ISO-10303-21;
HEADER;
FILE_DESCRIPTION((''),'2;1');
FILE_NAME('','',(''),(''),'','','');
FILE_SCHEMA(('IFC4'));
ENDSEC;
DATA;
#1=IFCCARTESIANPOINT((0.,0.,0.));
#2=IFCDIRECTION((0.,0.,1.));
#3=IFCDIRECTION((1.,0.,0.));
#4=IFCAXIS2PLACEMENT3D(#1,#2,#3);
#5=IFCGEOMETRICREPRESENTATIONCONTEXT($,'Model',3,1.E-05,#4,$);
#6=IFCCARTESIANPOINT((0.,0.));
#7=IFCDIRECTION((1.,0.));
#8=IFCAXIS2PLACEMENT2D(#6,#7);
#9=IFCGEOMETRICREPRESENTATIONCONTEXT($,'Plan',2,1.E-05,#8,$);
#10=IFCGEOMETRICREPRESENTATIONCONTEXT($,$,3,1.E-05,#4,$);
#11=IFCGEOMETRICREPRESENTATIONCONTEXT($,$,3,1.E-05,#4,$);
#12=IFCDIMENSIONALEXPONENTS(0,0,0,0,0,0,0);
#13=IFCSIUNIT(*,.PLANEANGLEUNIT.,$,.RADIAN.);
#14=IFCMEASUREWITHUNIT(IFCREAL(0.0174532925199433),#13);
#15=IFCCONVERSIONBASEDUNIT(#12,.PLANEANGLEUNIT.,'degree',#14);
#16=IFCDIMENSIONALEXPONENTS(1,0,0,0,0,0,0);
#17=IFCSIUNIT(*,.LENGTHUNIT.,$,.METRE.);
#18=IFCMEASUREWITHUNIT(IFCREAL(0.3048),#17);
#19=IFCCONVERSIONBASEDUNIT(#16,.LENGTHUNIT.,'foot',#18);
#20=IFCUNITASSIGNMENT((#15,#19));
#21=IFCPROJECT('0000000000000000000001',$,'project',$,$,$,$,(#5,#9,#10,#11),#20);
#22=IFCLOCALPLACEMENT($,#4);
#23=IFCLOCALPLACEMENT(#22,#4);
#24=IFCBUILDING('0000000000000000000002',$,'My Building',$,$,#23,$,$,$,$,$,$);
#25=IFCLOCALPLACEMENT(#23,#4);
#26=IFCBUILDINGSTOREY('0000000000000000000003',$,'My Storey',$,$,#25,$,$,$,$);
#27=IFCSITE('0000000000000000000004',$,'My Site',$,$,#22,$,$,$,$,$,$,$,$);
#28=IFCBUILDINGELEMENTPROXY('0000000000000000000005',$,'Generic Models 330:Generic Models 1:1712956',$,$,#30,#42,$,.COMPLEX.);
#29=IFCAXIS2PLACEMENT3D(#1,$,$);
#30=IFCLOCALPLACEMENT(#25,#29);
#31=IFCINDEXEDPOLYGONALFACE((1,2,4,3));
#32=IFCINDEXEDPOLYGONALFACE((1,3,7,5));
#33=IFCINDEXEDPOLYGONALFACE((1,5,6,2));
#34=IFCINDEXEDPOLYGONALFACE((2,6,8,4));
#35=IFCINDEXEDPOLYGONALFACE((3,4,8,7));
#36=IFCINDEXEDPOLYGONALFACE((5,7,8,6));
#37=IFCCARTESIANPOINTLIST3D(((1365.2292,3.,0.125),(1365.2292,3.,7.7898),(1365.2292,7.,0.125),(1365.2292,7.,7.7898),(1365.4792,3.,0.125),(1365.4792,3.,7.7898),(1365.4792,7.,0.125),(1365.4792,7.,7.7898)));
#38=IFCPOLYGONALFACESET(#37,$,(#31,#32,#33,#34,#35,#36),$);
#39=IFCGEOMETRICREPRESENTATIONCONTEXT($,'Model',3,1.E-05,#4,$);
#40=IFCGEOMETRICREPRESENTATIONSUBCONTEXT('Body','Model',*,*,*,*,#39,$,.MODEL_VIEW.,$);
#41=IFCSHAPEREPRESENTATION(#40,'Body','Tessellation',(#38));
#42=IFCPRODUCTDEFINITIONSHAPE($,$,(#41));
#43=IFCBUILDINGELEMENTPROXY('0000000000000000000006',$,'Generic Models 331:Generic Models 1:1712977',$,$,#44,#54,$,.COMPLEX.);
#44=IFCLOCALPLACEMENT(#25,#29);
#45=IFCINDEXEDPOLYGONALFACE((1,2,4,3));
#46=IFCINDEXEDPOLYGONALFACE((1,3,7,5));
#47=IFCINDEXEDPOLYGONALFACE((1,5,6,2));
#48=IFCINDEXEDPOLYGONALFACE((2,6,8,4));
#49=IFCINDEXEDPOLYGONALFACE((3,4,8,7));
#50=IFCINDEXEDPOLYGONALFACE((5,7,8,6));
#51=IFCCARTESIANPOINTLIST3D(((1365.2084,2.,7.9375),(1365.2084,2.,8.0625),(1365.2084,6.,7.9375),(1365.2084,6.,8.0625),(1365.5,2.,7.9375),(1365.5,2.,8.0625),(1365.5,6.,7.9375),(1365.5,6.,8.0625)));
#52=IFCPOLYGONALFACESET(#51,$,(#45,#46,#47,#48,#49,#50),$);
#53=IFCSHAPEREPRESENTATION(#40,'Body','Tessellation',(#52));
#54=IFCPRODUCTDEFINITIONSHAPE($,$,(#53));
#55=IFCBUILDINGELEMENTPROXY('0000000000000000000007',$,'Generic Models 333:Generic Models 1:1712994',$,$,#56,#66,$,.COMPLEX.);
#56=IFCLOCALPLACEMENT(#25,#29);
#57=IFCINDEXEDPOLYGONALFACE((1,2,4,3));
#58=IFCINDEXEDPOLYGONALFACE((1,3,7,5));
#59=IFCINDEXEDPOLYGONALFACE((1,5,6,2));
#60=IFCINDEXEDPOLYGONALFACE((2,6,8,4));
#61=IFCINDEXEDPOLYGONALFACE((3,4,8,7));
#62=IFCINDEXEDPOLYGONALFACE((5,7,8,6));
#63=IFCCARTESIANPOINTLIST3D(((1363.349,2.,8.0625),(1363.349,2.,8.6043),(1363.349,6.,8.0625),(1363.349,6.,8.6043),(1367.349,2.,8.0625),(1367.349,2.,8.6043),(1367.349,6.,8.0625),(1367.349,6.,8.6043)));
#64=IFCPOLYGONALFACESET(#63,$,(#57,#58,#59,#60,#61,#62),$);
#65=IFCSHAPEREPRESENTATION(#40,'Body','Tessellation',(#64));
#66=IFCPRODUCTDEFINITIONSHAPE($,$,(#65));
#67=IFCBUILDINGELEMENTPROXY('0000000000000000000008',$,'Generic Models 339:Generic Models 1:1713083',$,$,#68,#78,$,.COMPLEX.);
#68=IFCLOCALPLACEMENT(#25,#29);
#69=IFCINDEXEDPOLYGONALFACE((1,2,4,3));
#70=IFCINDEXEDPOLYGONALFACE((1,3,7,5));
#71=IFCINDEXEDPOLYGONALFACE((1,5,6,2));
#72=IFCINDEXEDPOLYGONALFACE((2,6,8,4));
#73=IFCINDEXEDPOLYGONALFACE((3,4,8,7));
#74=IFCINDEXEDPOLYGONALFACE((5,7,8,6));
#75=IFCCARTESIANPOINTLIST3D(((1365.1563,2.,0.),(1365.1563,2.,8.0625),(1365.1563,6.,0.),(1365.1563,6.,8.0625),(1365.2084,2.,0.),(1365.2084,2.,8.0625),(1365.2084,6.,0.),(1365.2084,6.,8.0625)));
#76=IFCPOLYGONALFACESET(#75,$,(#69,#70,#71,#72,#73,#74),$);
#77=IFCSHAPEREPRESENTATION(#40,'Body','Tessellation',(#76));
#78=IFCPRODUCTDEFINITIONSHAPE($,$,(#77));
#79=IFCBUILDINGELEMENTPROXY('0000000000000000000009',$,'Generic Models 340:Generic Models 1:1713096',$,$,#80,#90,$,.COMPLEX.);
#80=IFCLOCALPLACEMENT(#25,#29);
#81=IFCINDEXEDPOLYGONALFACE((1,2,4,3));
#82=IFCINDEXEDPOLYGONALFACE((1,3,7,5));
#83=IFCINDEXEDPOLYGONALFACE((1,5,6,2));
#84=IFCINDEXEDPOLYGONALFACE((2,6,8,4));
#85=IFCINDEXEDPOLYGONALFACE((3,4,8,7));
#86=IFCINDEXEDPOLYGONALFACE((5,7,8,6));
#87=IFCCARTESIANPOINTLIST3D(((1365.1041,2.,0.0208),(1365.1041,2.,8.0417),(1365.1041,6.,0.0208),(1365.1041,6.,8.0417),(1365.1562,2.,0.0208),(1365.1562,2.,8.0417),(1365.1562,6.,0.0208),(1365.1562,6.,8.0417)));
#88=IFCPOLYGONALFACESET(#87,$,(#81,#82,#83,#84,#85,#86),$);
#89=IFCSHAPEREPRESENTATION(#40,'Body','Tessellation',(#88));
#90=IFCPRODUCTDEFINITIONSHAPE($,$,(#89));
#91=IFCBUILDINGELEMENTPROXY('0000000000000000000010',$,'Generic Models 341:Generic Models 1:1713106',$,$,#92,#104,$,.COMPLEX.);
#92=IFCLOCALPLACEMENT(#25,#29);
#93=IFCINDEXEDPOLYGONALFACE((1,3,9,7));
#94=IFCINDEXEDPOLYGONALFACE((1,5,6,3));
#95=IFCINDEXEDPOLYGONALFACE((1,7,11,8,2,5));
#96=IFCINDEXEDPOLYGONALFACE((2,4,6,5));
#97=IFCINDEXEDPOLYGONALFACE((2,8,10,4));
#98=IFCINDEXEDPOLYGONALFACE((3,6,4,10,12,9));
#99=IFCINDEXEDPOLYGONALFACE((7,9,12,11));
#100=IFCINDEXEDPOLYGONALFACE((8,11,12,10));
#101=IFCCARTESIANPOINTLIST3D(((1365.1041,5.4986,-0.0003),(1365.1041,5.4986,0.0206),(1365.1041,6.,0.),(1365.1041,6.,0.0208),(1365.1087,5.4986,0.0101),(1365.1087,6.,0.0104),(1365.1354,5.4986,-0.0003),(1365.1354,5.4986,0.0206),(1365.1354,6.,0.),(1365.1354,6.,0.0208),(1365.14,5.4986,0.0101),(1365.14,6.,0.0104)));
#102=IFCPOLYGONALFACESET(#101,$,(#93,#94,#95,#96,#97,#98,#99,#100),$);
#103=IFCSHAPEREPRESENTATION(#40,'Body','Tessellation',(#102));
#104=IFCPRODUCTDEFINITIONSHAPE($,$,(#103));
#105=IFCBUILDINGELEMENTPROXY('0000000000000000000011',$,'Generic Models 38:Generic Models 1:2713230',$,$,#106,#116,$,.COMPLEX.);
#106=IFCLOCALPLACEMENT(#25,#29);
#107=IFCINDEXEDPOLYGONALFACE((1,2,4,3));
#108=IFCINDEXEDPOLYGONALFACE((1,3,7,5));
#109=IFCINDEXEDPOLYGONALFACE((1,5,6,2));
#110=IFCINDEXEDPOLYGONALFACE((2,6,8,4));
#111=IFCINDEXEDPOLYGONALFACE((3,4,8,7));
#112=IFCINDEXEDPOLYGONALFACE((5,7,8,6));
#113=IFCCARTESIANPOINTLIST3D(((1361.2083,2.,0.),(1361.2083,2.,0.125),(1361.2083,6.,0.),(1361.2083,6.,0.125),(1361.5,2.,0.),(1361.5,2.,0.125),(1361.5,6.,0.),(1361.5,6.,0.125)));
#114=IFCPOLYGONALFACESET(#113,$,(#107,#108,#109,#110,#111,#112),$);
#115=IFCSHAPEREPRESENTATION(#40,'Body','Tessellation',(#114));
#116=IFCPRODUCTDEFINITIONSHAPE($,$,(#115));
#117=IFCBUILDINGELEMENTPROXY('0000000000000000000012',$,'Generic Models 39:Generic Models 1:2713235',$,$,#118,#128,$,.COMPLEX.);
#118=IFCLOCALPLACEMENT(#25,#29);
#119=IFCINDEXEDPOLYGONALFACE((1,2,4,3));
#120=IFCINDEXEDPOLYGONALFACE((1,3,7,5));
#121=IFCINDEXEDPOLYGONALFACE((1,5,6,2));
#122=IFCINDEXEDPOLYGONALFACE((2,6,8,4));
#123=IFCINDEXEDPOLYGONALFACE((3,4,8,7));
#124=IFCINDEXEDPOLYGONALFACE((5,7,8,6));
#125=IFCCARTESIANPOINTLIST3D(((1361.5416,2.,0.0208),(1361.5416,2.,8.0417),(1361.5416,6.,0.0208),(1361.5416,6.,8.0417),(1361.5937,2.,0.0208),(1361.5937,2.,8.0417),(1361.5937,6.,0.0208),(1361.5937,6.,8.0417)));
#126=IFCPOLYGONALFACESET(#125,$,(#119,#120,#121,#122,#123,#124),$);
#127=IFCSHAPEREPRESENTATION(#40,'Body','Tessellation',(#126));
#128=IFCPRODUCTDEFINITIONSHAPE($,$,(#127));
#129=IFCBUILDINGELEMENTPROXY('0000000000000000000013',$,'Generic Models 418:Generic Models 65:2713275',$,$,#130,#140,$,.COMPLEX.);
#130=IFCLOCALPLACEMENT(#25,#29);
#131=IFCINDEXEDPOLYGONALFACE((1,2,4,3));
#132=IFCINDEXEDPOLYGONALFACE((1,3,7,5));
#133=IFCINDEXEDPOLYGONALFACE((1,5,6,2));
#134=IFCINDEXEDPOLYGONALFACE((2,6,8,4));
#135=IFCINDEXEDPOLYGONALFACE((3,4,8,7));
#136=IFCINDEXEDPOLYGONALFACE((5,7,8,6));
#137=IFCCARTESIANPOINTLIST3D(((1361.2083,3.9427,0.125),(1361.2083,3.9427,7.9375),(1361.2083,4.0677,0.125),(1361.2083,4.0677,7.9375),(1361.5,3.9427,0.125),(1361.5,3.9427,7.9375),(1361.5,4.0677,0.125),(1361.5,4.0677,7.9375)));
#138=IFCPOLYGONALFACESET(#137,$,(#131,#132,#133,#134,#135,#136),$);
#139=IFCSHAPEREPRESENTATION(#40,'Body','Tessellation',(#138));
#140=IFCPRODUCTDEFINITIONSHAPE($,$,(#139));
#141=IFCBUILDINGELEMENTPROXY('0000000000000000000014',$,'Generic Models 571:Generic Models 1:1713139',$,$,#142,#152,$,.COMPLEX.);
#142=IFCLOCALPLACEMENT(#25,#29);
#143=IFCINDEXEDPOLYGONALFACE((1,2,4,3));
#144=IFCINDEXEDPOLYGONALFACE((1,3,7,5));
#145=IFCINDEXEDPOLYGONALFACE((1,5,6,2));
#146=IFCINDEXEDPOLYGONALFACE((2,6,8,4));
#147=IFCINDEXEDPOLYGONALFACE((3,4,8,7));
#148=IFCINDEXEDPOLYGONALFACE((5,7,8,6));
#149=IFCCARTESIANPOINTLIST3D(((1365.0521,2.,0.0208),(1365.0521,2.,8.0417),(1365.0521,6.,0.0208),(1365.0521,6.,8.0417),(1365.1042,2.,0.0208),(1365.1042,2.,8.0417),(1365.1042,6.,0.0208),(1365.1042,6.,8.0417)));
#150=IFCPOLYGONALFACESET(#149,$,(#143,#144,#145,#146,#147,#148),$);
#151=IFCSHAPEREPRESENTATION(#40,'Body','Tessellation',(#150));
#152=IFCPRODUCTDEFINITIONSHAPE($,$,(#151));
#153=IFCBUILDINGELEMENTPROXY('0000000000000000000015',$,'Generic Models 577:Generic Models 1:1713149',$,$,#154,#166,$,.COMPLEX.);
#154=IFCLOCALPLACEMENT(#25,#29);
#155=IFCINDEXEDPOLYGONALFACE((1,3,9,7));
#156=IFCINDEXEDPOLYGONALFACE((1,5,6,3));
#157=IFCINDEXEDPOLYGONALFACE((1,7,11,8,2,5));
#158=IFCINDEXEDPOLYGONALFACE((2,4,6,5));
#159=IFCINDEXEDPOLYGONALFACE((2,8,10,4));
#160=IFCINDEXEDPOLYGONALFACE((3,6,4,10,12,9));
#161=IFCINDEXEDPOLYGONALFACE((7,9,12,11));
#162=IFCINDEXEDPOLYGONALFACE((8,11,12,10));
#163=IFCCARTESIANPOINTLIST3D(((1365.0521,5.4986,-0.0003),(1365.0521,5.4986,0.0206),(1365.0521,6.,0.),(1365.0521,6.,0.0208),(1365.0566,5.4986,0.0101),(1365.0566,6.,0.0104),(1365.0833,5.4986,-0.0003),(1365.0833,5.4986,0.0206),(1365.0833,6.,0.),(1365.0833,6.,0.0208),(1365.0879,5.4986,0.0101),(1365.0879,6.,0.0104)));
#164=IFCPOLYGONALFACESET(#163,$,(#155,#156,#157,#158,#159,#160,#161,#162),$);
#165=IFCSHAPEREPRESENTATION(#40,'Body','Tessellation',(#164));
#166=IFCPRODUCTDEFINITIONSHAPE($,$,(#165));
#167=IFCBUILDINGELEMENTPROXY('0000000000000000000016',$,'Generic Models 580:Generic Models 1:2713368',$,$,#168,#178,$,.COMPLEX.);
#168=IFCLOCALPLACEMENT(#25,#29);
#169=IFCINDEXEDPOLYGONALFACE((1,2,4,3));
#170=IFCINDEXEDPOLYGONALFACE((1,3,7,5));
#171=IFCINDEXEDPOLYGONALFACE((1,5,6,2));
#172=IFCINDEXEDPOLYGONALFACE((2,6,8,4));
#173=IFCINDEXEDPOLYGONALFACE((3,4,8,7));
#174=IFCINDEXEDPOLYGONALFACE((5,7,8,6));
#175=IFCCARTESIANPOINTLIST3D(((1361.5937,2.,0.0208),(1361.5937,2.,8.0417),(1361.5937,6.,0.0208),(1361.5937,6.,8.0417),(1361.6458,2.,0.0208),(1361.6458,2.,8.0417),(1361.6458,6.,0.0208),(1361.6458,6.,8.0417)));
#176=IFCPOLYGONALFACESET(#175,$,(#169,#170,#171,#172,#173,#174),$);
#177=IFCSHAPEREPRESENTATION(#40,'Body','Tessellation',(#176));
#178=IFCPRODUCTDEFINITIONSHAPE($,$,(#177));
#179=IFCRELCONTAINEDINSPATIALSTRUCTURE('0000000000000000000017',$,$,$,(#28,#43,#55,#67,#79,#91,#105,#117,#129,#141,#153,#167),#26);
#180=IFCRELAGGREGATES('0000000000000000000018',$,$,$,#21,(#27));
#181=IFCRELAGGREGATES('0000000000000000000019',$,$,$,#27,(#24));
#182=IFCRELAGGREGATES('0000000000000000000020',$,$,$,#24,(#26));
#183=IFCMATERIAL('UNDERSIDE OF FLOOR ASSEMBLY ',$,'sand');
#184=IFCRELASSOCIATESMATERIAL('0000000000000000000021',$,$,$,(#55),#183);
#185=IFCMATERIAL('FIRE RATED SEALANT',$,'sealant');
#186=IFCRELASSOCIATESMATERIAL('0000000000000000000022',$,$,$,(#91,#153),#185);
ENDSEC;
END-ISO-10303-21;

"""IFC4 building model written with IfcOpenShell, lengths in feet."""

from ifc_helpers import new_model, entity, si_unit, converted_unit, frame, origin_with_axes, origin_2d_with_axis, place, context, subcontext, project, spatial, polyline, line, indexed_curve, outline, extrude, material, element, save


model = new_model("IFC4")

# Units and contexts
model_context_1 = context("Model", 3, precision=1e-05, world=origin_with_axes())
plan_context = context("Plan", 2, precision=1e-05, world=origin_2d_with_axis())
model_context_2 = context("Model", 3, precision=1e-05, world=origin_with_axes())
context_of_model_1 = context(None, 3, precision=1e-05, world=origin_with_axes())
context_of_model_2 = context(None, 3, precision=1e-05, world=origin_with_axes())
body_context = subcontext(model_context_2, "Body", "Model", "MODEL_VIEW")
ifc_project = project(units=[converted_unit("PLANEANGLEUNIT", "degree", entity("IfcReal", 0.0174532925199433), si_unit("PLANEANGLEUNIT", "RADIAN"), dimensions=[0, 0, 0, 0, 0, 0, 0]), converted_unit("LENGTHUNIT", "foot", entity("IfcReal", 0.3048), si_unit("LENGTHUNIT", "METRE"), dimensions=[1, 0, 0, 0, 0, 0, 0])], contexts=[model_context_1, plan_context, context_of_model_1, context_of_model_2])

# Site, building, storey
site_placement = place(None, origin_with_axes())
site = spatial("IfcSite", under=ifc_project, at=site_placement, Name="My Site")
building_placement = place(site_placement, origin_with_axes())
building = spatial("IfcBuilding", under=site, at=building_placement, Name="My Building")
storey_placement = place(building_placement, origin_with_axes())
storey = spatial("IfcBuildingStorey", under=building, at=storey_placement, Name="My Storey")

# Building element proxies
ifc_material_1 = material(Name="FIRE RATED SEALANT", Category="sealant")
proxy_1_placement = place(storey_placement, frame((1365.2292, 3.0, 0.125), z_axis=(0.0, 0.0, 1.0), x_axis=(0.0, 1.0, 0.0)))
element("IfcBuildingElementProxy", 1, at=proxy_1_placement, inside=storey, Name="Generic Models 330:Generic Models 1:1712956", PredefinedType="COMPLEX", context=body_context, shape_type="SweptSolid", body=[
    extrude(outline(polyline([(-2.0, -0.125), (2.0, -0.125), (2.0, 0.125), (-2.0, 0.125), (-2.0, -0.125)])), frame((2.0, -0.125, 0.0), z_axis=(0.0, 0.0, -1.0), x_axis=(-1.0, 0.0, 0.0)), (0.0, 0.0, -1.0), 7.6648),
])
proxy_2_placement = place(storey_placement, frame((1365.2084, 6.0, 7.9375), z_axis=(0.0, -1.0, 0.0), x_axis=(0.0, 0.0, 1.0)))
element("IfcBuildingElementProxy", 2, at=proxy_2_placement, inside=storey, Name="Generic Models 331:Generic Models 1:1712977", PredefinedType="COMPLEX", context=body_context, shape_type="SweptSolid", body=[
    extrude(outline(polyline([(-0.1458, -0.0625), (0.1458, -0.0625), (0.1458, 0.0625), (-0.1458, 0.0625), (-0.1458, -0.0625)])), frame((0.0625, -0.1458, 0.0), z_axis=(0.0, 0.0, -1.0), x_axis=(0.0, 1.0, 0.0)), (0.0, 0.0, -1.0), 4.0),
])
ifc_material_2 = material(Name="UNDERSIDE OF FLOOR ASSEMBLY ", Category="sand")
proxy_3_placement = place(storey_placement, frame((1363.349, 6.0, 8.0625), z_axis=(0.0, -1.0, 0.0), x_axis=(0.0, 0.0, 1.0)))
element("IfcBuildingElementProxy", 3, at=proxy_3_placement, inside=storey, material=ifc_material_2, Name="Generic Models 333:Generic Models 1:1712994", PredefinedType="COMPLEX", context=body_context, shape_type="SweptSolid", body=[
    extrude(outline(polyline([(-0.2709, -2.0), (0.2709, -2.0), (0.2709, 2.0), (-0.2709, 2.0), (-0.2709, -2.0)])), frame((0.2709, -2.0, 0.0), z_axis=(0.0, 0.0, -1.0), x_axis=(1.0, 0.0, 0.0)), (0.0, 0.0, -1.0), 4.0),
])
proxy_4_placement = place(storey_placement, frame((1365.1563, 6.0, 0.0), z_axis=(0.0, -1.0, 0.0), x_axis=(0.0, 0.0, 1.0)))
element("IfcBuildingElementProxy", 4, at=proxy_4_placement, inside=storey, Name="Generic Models 339:Generic Models 1:1713083", PredefinedType="COMPLEX", context=body_context, shape_type="SweptSolid", body=[
    extrude(outline(polyline([(-4.0312, -0.026), (4.0312, -0.026), (4.0312, 0.026), (-4.0312, 0.026), (-4.0312, -0.026)])), frame((4.0312, -0.026, 0.0), z_axis=(0.0, 0.0, -1.0), x_axis=(-1.0, 0.0, 0.0)), (0.0, 0.0, -1.0), 4.0),
])
proxy_5_placement = place(storey_placement, frame((1365.1041, 6.0, 0.0208), z_axis=(0.0, -1.0, 0.0), x_axis=(0.0, 0.0, 1.0)))
element("IfcBuildingElementProxy", 5, at=proxy_5_placement, inside=storey, Name="Generic Models 340:Generic Models 1:1713096", PredefinedType="COMPLEX", context=body_context, shape_type="SweptSolid", body=[
    extrude(outline(polyline([(-0.026, -4.0104), (0.026, -4.0104), (0.026, 4.0104), (-0.026, 4.0104), (-0.026, -4.0104)])), frame((4.0104, -0.026, 0.0), z_axis=(0.0, 0.0, -1.0), x_axis=(0.0, 1.0, 0.0)), (0.0, 0.0, -1.0), 4.0),
])
proxy_6_placement = place(storey_placement, frame((1365.1041, 6.0, 0.0), z_axis=(0.0, -1.0, 0.0), x_axis=(0.0, 0.0, 1.0)))
element("IfcBuildingElementProxy", 6, at=proxy_6_placement, inside=storey, material=ifc_material_1, Name="Generic Models 341:Generic Models 1:1713106", PredefinedType="COMPLEX", context=body_context, shape_type="SweptSolid", body=[
    extrude(outline(polyline([(0.0201, 0.0), (-0.0066, 0.0162), (-0.016, 0.0097), (-0.0175, -0.0016), (0.0093, -0.0178), (0.0107, -0.0065), (0.0201, 0.0)])), frame((0.0104, -0.0172, 0.0), z_axis=(0.0, 0.0, -1.0), x_axis=(0.51911, 0.854708, 0.0)), (-0.000285, -0.000479, -1.0), 0.5014),
])
proxy_7_placement = place(storey_placement, frame((1361.2083, 6.0, 0.0), z_axis=(0.0, -1.0, 0.0), x_axis=(0.0, 0.0, 1.0)))
element("IfcBuildingElementProxy", 7, at=proxy_7_placement, inside=storey, Name="Generic Models 38:Generic Models 1:2713230", PredefinedType="COMPLEX", context=body_context, shape_type="SweptSolid", body=[
    extrude(outline(polyline([(-0.0625, -0.1458), (0.0625, -0.1458), (0.0625, 0.1458), (-0.0625, 0.1458), (-0.0625, -0.1458)])), frame((0.0625, -0.1458, 0.0), z_axis=(0.0, 0.0, -1.0), x_axis=(1.0, 0.0, 0.0)), (0.0, 0.0, -1.0), 4.0),
])
proxy_8_placement = place(storey_placement, frame((1361.5416, 6.0, 0.0208), z_axis=(0.0, -1.0, 0.0), x_axis=(0.0, 0.0, 1.0)))
element("IfcBuildingElementProxy", 8, at=proxy_8_placement, inside=storey, Name="Generic Models 39:Generic Models 1:2713235", PredefinedType="COMPLEX", context=body_context, shape_type="SweptSolid", body=[
    extrude(outline(polyline([(-0.026, -4.0104), (0.026, -4.0104), (0.026, 4.0104), (-0.026, 4.0104), (-0.026, -4.0104)])), frame((4.0104, -0.026, 0.0), z_axis=(0.0, 0.0, -1.0), x_axis=(0.0, 1.0, 0.0)), (0.0, 0.0, -1.0), 4.0),
])
proxy_9_placement = place(storey_placement, frame((1361.2083, 3.9427, 0.125), z_axis=(0.0, 0.0, 1.0), x_axis=(1.0, 0.0, 0.0)))
element("IfcBuildingElementProxy", 9, at=proxy_9_placement, inside=storey, Name="Generic Models 418:Generic Models 65:2713275", PredefinedType="COMPLEX", context=body_context, shape_type="SweptSolid", body=[
    extrude(outline(polyline([(-0.1458, -0.0625), (0.1458, -0.0625), (0.1458, 0.0625), (-0.1458, 0.0625), (-0.1458, -0.0625)])), frame((0.1458, 0.0625, 0.0), z_axis=(0.0, 0.0, -1.0), x_axis=(-1.0, 0.0, 0.0)), (0.0, 0.0, -1.0), 7.8125),
])
proxy_10_placement = place(storey_placement, frame((1365.0521, 6.0, 0.0208), z_axis=(0.0, -1.0, 0.0), x_axis=(0.0, 0.0, 1.0)))
element("IfcBuildingElementProxy", 10, at=proxy_10_placement, inside=storey, Name="Generic Models 571:Generic Models 1:1713139", PredefinedType="COMPLEX", context=body_context, shape_type="SweptSolid", body=[
    extrude(outline(indexed_curve([(-4.0104, -0.026), (4.0104, -0.026), (4.0104, 0.026), (-4.0104, 0.026)], segments=[line(4, 1), line(1, 2), line(2, 3), line(3, 4)], self_intersect=False)), frame((4.0104, -0.026, 0.0), z_axis=(0.0, 0.0, -1.0), x_axis=(1.0, 0.0, 0.0)), (0.0, 0.0, -1.0), 4.0),
])
proxy_11_placement = place(storey_placement, frame((1365.0521, 6.0, 0.0), z_axis=(0.0, -1.0, 0.0), x_axis=(0.0, 0.0, 1.0)))
element("IfcBuildingElementProxy", 11, at=proxy_11_placement, inside=storey, material=ifc_material_1, Name="Generic Models 577:Generic Models 1:1713149", PredefinedType="COMPLEX", context=body_context, shape_type="SweptSolid", body=[
    extrude(outline(polyline([(0.0201, 0.0), (-0.0066, 0.0162), (-0.016, 0.0097), (-0.0175, -0.0016), (0.0093, -0.0178), (0.0107, -0.0065), (0.0201, 0.0)])), frame((0.0104, -0.0172, 0.0), z_axis=(0.0, 0.0, -1.0), x_axis=(0.51911, 0.854708, 0.0)), (-0.000285, -0.000479, -1.0), 0.5014),
])
proxy_12_placement = place(storey_placement, frame((1361.5937, 6.0, 0.0208), z_axis=(0.0, -1.0, 0.0), x_axis=(0.0, 0.0, 1.0)))
element("IfcBuildingElementProxy", 12, at=proxy_12_placement, inside=storey, Name="Generic Models 580:Generic Models 1:2713368", PredefinedType="COMPLEX", context=body_context, shape_type="SweptSolid", body=[
    extrude(outline(polyline([(-4.0104, -0.026), (4.0104, -0.026), (4.0104, 0.026), (-4.0104, 0.026), (-4.0104, -0.026)])), frame((4.0104, -0.026, 0.0), z_axis=(0.0, 0.0, -1.0), x_axis=(1.0, 0.0, 0.0)), (0.0, 0.0, -1.0), 4.0),
])

save(model, "model.ifc")
